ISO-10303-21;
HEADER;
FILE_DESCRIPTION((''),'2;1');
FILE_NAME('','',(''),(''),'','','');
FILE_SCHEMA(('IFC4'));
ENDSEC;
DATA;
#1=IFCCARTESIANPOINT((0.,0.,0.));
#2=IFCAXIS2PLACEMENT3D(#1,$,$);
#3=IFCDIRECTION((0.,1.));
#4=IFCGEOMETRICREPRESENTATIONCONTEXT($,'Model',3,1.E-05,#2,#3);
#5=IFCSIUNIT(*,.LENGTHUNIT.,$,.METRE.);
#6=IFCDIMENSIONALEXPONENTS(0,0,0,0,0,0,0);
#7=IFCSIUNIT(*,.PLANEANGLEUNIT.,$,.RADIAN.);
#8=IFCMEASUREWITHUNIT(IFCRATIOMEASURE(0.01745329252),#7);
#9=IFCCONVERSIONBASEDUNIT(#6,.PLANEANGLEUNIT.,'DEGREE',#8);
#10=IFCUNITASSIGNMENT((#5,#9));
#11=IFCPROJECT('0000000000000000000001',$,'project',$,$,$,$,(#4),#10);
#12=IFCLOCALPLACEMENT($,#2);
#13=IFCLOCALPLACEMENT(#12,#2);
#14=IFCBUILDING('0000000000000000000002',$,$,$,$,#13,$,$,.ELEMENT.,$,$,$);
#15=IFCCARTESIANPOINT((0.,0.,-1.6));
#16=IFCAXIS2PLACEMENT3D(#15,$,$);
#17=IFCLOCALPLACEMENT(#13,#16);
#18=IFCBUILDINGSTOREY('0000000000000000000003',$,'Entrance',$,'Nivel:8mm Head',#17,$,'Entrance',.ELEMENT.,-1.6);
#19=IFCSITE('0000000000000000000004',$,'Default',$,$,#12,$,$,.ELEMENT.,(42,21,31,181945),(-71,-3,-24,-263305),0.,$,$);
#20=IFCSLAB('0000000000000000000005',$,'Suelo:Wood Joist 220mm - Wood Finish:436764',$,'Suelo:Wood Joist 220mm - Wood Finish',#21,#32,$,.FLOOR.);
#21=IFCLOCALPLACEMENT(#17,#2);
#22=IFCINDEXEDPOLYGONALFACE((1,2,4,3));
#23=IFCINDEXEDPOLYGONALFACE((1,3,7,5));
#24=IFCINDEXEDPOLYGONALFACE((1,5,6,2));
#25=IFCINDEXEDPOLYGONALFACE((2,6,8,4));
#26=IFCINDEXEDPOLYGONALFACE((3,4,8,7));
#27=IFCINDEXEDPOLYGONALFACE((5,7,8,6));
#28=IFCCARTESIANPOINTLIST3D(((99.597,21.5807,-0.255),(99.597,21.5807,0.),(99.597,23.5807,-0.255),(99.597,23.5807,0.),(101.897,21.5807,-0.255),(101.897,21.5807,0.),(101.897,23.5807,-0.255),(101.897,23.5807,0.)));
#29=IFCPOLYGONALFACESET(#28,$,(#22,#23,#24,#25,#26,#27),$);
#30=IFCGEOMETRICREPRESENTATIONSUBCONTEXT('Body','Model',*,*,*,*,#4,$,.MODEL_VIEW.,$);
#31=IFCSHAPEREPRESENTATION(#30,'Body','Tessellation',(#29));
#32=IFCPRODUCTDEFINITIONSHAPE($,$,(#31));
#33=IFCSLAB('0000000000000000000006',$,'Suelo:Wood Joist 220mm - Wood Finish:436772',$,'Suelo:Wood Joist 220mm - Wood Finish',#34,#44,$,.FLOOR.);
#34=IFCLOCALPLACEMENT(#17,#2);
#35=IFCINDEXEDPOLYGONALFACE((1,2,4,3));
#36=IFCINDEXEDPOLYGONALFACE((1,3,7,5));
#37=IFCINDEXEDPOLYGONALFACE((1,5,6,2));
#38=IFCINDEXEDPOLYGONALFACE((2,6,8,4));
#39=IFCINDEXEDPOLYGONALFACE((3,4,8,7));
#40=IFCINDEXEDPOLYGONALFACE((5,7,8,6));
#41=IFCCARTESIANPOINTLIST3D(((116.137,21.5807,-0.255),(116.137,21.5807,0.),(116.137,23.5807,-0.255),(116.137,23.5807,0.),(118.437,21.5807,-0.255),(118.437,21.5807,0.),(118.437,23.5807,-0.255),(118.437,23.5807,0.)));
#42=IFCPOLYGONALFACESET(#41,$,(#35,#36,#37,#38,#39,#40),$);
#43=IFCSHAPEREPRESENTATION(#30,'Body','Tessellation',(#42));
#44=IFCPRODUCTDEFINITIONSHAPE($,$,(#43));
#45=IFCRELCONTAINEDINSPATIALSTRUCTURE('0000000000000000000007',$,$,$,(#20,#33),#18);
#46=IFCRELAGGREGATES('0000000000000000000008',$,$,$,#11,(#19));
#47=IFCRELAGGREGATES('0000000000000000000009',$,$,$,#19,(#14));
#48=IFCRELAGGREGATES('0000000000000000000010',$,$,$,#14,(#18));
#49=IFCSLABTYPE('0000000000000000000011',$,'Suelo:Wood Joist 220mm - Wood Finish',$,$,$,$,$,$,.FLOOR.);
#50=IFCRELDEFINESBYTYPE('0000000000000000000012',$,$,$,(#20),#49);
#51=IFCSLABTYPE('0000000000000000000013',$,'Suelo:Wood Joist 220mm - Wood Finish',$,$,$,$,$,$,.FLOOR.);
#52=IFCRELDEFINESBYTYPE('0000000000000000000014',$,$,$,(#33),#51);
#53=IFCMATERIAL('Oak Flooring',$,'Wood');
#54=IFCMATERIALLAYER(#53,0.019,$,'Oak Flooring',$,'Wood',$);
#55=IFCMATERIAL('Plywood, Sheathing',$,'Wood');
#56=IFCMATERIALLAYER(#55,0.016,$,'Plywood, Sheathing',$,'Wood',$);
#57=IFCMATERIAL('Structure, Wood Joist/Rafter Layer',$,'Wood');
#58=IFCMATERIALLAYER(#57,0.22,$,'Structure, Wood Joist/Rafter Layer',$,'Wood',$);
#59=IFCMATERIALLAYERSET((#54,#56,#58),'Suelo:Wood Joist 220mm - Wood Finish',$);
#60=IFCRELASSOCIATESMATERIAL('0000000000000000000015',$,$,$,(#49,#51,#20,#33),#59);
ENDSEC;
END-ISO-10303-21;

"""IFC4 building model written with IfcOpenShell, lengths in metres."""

from ifc_helpers import new_model, entity, si_unit, converted_unit, direction, frame, origin, origin_2d_with_axis, place, context, subcontext, project, spatial, rectangle, extrude, material, layer, layer_set, layer_usage, type_object, element, save


model = new_model("IFC4")

# Units and contexts
model_context = context("Model", 3, precision=1e-05, world=origin(), true_north=direction((0.0, 1.0)))
body_context = subcontext(model_context, "Body", "Model", "MODEL_VIEW")
ifc_project = project(units=[si_unit("LENGTHUNIT", "METRE"), converted_unit("PLANEANGLEUNIT", "DEGREE", entity("IfcRatioMeasure", 0.01745329252), si_unit("PLANEANGLEUNIT", "RADIAN"), dimensions=[0, 0, 0, 0, 0, 0, 0])], contexts=[model_context])

# Site, building, storey
site_placement = place(None, origin())
site = spatial("IfcSite", under=ifc_project, at=site_placement, Name="Default", CompositionType="ELEMENT", RefLatitude=(42, 21, 31, 181945), RefLongitude=(-71, -3, -24, -263305), RefElevation=0.0)
building_placement = place(site_placement, origin())
building = spatial("IfcBuilding", under=site, at=building_placement, CompositionType="ELEMENT")
storey_placement = place(building_placement, frame((0.0, 0.0, -1.6)))
storey = spatial("IfcBuildingStorey", under=building, at=storey_placement, Name="Entrance", ObjectType="Nivel:8mm Head", LongName="Entrance", CompositionType="ELEMENT", Elevation=-1.6)

# Slabs
ifc_material_1 = material(Name="Oak Flooring", Category="Wood")
ifc_layer_1 = layer(ifc_material_1, 0.019, Name="Oak Flooring", Category="Wood")
ifc_material_2 = material(Name="Plywood, Sheathing", Category="Wood")
ifc_layer_2 = layer(ifc_material_2, 0.016, Name="Plywood, Sheathing", Category="Wood")
ifc_material_3 = material(Name="Structure, Wood Joist/Rafter Layer", Category="Wood")
ifc_layer_3 = layer(ifc_material_3, 0.22, Name="Structure, Wood Joist/Rafter Layer", Category="Wood")
ifc_layer_set_1 = layer_set([ifc_layer_1, ifc_layer_2, ifc_layer_3], Name="Suelo:Wood Joist 220mm - Wood Finish")
ifc_layer_usage_1 = layer_usage(ifc_layer_set_1, "AXIS3", "POSITIVE", 0.0)
slab_type_1 = type_object("IfcSlabType", Name="Suelo:Wood Joist 220mm - Wood Finish", PredefinedType="FLOOR", material=ifc_layer_set_1)
slab_1_placement = place(storey_placement, origin())
element("IfcSlab", 1, at=slab_1_placement, inside=storey, type_object=slab_type_1, material=ifc_layer_usage_1, Name="Suelo:Wood Joist 220mm - Wood Finish:436764", ObjectType="Suelo:Wood Joist 220mm - Wood Finish", PredefinedType="FLOOR", context=body_context, shape_type="SweptSolid", body=[
    extrude(rectangle(XDim=2.0, YDim=2.3, at=origin_2d_with_axis()), frame((100.747, 22.5807, 0.0), z_axis=(0.0, 0.0, -1.0), x_axis=(0.0, 1.0, 0.0)), (0.0, 0.0, 1.0), 0.255),
])
ifc_layer_usage_2 = layer_usage(ifc_layer_set_1, "AXIS3", "POSITIVE", 0.0)
slab_type_2 = type_object("IfcSlabType", Name="Suelo:Wood Joist 220mm - Wood Finish", PredefinedType="FLOOR", material=ifc_layer_set_1)
slab_2_placement = place(storey_placement, origin())
element("IfcSlab", 2, at=slab_2_placement, inside=storey, type_object=slab_type_2, material=ifc_layer_usage_2, Name="Suelo:Wood Joist 220mm - Wood Finish:436772", ObjectType="Suelo:Wood Joist 220mm - Wood Finish", PredefinedType="FLOOR", context=body_context, shape_type="SweptSolid", body=[
    extrude(rectangle(XDim=2.0, YDim=2.3, at=origin_2d_with_axis()), frame((117.287, 22.5807, 0.0), z_axis=(0.0, 0.0, -1.0), x_axis=(0.0, 1.0, 0.0)), (0.0, 0.0, 1.0), 0.255),
])

save(model, "model.ifc")
